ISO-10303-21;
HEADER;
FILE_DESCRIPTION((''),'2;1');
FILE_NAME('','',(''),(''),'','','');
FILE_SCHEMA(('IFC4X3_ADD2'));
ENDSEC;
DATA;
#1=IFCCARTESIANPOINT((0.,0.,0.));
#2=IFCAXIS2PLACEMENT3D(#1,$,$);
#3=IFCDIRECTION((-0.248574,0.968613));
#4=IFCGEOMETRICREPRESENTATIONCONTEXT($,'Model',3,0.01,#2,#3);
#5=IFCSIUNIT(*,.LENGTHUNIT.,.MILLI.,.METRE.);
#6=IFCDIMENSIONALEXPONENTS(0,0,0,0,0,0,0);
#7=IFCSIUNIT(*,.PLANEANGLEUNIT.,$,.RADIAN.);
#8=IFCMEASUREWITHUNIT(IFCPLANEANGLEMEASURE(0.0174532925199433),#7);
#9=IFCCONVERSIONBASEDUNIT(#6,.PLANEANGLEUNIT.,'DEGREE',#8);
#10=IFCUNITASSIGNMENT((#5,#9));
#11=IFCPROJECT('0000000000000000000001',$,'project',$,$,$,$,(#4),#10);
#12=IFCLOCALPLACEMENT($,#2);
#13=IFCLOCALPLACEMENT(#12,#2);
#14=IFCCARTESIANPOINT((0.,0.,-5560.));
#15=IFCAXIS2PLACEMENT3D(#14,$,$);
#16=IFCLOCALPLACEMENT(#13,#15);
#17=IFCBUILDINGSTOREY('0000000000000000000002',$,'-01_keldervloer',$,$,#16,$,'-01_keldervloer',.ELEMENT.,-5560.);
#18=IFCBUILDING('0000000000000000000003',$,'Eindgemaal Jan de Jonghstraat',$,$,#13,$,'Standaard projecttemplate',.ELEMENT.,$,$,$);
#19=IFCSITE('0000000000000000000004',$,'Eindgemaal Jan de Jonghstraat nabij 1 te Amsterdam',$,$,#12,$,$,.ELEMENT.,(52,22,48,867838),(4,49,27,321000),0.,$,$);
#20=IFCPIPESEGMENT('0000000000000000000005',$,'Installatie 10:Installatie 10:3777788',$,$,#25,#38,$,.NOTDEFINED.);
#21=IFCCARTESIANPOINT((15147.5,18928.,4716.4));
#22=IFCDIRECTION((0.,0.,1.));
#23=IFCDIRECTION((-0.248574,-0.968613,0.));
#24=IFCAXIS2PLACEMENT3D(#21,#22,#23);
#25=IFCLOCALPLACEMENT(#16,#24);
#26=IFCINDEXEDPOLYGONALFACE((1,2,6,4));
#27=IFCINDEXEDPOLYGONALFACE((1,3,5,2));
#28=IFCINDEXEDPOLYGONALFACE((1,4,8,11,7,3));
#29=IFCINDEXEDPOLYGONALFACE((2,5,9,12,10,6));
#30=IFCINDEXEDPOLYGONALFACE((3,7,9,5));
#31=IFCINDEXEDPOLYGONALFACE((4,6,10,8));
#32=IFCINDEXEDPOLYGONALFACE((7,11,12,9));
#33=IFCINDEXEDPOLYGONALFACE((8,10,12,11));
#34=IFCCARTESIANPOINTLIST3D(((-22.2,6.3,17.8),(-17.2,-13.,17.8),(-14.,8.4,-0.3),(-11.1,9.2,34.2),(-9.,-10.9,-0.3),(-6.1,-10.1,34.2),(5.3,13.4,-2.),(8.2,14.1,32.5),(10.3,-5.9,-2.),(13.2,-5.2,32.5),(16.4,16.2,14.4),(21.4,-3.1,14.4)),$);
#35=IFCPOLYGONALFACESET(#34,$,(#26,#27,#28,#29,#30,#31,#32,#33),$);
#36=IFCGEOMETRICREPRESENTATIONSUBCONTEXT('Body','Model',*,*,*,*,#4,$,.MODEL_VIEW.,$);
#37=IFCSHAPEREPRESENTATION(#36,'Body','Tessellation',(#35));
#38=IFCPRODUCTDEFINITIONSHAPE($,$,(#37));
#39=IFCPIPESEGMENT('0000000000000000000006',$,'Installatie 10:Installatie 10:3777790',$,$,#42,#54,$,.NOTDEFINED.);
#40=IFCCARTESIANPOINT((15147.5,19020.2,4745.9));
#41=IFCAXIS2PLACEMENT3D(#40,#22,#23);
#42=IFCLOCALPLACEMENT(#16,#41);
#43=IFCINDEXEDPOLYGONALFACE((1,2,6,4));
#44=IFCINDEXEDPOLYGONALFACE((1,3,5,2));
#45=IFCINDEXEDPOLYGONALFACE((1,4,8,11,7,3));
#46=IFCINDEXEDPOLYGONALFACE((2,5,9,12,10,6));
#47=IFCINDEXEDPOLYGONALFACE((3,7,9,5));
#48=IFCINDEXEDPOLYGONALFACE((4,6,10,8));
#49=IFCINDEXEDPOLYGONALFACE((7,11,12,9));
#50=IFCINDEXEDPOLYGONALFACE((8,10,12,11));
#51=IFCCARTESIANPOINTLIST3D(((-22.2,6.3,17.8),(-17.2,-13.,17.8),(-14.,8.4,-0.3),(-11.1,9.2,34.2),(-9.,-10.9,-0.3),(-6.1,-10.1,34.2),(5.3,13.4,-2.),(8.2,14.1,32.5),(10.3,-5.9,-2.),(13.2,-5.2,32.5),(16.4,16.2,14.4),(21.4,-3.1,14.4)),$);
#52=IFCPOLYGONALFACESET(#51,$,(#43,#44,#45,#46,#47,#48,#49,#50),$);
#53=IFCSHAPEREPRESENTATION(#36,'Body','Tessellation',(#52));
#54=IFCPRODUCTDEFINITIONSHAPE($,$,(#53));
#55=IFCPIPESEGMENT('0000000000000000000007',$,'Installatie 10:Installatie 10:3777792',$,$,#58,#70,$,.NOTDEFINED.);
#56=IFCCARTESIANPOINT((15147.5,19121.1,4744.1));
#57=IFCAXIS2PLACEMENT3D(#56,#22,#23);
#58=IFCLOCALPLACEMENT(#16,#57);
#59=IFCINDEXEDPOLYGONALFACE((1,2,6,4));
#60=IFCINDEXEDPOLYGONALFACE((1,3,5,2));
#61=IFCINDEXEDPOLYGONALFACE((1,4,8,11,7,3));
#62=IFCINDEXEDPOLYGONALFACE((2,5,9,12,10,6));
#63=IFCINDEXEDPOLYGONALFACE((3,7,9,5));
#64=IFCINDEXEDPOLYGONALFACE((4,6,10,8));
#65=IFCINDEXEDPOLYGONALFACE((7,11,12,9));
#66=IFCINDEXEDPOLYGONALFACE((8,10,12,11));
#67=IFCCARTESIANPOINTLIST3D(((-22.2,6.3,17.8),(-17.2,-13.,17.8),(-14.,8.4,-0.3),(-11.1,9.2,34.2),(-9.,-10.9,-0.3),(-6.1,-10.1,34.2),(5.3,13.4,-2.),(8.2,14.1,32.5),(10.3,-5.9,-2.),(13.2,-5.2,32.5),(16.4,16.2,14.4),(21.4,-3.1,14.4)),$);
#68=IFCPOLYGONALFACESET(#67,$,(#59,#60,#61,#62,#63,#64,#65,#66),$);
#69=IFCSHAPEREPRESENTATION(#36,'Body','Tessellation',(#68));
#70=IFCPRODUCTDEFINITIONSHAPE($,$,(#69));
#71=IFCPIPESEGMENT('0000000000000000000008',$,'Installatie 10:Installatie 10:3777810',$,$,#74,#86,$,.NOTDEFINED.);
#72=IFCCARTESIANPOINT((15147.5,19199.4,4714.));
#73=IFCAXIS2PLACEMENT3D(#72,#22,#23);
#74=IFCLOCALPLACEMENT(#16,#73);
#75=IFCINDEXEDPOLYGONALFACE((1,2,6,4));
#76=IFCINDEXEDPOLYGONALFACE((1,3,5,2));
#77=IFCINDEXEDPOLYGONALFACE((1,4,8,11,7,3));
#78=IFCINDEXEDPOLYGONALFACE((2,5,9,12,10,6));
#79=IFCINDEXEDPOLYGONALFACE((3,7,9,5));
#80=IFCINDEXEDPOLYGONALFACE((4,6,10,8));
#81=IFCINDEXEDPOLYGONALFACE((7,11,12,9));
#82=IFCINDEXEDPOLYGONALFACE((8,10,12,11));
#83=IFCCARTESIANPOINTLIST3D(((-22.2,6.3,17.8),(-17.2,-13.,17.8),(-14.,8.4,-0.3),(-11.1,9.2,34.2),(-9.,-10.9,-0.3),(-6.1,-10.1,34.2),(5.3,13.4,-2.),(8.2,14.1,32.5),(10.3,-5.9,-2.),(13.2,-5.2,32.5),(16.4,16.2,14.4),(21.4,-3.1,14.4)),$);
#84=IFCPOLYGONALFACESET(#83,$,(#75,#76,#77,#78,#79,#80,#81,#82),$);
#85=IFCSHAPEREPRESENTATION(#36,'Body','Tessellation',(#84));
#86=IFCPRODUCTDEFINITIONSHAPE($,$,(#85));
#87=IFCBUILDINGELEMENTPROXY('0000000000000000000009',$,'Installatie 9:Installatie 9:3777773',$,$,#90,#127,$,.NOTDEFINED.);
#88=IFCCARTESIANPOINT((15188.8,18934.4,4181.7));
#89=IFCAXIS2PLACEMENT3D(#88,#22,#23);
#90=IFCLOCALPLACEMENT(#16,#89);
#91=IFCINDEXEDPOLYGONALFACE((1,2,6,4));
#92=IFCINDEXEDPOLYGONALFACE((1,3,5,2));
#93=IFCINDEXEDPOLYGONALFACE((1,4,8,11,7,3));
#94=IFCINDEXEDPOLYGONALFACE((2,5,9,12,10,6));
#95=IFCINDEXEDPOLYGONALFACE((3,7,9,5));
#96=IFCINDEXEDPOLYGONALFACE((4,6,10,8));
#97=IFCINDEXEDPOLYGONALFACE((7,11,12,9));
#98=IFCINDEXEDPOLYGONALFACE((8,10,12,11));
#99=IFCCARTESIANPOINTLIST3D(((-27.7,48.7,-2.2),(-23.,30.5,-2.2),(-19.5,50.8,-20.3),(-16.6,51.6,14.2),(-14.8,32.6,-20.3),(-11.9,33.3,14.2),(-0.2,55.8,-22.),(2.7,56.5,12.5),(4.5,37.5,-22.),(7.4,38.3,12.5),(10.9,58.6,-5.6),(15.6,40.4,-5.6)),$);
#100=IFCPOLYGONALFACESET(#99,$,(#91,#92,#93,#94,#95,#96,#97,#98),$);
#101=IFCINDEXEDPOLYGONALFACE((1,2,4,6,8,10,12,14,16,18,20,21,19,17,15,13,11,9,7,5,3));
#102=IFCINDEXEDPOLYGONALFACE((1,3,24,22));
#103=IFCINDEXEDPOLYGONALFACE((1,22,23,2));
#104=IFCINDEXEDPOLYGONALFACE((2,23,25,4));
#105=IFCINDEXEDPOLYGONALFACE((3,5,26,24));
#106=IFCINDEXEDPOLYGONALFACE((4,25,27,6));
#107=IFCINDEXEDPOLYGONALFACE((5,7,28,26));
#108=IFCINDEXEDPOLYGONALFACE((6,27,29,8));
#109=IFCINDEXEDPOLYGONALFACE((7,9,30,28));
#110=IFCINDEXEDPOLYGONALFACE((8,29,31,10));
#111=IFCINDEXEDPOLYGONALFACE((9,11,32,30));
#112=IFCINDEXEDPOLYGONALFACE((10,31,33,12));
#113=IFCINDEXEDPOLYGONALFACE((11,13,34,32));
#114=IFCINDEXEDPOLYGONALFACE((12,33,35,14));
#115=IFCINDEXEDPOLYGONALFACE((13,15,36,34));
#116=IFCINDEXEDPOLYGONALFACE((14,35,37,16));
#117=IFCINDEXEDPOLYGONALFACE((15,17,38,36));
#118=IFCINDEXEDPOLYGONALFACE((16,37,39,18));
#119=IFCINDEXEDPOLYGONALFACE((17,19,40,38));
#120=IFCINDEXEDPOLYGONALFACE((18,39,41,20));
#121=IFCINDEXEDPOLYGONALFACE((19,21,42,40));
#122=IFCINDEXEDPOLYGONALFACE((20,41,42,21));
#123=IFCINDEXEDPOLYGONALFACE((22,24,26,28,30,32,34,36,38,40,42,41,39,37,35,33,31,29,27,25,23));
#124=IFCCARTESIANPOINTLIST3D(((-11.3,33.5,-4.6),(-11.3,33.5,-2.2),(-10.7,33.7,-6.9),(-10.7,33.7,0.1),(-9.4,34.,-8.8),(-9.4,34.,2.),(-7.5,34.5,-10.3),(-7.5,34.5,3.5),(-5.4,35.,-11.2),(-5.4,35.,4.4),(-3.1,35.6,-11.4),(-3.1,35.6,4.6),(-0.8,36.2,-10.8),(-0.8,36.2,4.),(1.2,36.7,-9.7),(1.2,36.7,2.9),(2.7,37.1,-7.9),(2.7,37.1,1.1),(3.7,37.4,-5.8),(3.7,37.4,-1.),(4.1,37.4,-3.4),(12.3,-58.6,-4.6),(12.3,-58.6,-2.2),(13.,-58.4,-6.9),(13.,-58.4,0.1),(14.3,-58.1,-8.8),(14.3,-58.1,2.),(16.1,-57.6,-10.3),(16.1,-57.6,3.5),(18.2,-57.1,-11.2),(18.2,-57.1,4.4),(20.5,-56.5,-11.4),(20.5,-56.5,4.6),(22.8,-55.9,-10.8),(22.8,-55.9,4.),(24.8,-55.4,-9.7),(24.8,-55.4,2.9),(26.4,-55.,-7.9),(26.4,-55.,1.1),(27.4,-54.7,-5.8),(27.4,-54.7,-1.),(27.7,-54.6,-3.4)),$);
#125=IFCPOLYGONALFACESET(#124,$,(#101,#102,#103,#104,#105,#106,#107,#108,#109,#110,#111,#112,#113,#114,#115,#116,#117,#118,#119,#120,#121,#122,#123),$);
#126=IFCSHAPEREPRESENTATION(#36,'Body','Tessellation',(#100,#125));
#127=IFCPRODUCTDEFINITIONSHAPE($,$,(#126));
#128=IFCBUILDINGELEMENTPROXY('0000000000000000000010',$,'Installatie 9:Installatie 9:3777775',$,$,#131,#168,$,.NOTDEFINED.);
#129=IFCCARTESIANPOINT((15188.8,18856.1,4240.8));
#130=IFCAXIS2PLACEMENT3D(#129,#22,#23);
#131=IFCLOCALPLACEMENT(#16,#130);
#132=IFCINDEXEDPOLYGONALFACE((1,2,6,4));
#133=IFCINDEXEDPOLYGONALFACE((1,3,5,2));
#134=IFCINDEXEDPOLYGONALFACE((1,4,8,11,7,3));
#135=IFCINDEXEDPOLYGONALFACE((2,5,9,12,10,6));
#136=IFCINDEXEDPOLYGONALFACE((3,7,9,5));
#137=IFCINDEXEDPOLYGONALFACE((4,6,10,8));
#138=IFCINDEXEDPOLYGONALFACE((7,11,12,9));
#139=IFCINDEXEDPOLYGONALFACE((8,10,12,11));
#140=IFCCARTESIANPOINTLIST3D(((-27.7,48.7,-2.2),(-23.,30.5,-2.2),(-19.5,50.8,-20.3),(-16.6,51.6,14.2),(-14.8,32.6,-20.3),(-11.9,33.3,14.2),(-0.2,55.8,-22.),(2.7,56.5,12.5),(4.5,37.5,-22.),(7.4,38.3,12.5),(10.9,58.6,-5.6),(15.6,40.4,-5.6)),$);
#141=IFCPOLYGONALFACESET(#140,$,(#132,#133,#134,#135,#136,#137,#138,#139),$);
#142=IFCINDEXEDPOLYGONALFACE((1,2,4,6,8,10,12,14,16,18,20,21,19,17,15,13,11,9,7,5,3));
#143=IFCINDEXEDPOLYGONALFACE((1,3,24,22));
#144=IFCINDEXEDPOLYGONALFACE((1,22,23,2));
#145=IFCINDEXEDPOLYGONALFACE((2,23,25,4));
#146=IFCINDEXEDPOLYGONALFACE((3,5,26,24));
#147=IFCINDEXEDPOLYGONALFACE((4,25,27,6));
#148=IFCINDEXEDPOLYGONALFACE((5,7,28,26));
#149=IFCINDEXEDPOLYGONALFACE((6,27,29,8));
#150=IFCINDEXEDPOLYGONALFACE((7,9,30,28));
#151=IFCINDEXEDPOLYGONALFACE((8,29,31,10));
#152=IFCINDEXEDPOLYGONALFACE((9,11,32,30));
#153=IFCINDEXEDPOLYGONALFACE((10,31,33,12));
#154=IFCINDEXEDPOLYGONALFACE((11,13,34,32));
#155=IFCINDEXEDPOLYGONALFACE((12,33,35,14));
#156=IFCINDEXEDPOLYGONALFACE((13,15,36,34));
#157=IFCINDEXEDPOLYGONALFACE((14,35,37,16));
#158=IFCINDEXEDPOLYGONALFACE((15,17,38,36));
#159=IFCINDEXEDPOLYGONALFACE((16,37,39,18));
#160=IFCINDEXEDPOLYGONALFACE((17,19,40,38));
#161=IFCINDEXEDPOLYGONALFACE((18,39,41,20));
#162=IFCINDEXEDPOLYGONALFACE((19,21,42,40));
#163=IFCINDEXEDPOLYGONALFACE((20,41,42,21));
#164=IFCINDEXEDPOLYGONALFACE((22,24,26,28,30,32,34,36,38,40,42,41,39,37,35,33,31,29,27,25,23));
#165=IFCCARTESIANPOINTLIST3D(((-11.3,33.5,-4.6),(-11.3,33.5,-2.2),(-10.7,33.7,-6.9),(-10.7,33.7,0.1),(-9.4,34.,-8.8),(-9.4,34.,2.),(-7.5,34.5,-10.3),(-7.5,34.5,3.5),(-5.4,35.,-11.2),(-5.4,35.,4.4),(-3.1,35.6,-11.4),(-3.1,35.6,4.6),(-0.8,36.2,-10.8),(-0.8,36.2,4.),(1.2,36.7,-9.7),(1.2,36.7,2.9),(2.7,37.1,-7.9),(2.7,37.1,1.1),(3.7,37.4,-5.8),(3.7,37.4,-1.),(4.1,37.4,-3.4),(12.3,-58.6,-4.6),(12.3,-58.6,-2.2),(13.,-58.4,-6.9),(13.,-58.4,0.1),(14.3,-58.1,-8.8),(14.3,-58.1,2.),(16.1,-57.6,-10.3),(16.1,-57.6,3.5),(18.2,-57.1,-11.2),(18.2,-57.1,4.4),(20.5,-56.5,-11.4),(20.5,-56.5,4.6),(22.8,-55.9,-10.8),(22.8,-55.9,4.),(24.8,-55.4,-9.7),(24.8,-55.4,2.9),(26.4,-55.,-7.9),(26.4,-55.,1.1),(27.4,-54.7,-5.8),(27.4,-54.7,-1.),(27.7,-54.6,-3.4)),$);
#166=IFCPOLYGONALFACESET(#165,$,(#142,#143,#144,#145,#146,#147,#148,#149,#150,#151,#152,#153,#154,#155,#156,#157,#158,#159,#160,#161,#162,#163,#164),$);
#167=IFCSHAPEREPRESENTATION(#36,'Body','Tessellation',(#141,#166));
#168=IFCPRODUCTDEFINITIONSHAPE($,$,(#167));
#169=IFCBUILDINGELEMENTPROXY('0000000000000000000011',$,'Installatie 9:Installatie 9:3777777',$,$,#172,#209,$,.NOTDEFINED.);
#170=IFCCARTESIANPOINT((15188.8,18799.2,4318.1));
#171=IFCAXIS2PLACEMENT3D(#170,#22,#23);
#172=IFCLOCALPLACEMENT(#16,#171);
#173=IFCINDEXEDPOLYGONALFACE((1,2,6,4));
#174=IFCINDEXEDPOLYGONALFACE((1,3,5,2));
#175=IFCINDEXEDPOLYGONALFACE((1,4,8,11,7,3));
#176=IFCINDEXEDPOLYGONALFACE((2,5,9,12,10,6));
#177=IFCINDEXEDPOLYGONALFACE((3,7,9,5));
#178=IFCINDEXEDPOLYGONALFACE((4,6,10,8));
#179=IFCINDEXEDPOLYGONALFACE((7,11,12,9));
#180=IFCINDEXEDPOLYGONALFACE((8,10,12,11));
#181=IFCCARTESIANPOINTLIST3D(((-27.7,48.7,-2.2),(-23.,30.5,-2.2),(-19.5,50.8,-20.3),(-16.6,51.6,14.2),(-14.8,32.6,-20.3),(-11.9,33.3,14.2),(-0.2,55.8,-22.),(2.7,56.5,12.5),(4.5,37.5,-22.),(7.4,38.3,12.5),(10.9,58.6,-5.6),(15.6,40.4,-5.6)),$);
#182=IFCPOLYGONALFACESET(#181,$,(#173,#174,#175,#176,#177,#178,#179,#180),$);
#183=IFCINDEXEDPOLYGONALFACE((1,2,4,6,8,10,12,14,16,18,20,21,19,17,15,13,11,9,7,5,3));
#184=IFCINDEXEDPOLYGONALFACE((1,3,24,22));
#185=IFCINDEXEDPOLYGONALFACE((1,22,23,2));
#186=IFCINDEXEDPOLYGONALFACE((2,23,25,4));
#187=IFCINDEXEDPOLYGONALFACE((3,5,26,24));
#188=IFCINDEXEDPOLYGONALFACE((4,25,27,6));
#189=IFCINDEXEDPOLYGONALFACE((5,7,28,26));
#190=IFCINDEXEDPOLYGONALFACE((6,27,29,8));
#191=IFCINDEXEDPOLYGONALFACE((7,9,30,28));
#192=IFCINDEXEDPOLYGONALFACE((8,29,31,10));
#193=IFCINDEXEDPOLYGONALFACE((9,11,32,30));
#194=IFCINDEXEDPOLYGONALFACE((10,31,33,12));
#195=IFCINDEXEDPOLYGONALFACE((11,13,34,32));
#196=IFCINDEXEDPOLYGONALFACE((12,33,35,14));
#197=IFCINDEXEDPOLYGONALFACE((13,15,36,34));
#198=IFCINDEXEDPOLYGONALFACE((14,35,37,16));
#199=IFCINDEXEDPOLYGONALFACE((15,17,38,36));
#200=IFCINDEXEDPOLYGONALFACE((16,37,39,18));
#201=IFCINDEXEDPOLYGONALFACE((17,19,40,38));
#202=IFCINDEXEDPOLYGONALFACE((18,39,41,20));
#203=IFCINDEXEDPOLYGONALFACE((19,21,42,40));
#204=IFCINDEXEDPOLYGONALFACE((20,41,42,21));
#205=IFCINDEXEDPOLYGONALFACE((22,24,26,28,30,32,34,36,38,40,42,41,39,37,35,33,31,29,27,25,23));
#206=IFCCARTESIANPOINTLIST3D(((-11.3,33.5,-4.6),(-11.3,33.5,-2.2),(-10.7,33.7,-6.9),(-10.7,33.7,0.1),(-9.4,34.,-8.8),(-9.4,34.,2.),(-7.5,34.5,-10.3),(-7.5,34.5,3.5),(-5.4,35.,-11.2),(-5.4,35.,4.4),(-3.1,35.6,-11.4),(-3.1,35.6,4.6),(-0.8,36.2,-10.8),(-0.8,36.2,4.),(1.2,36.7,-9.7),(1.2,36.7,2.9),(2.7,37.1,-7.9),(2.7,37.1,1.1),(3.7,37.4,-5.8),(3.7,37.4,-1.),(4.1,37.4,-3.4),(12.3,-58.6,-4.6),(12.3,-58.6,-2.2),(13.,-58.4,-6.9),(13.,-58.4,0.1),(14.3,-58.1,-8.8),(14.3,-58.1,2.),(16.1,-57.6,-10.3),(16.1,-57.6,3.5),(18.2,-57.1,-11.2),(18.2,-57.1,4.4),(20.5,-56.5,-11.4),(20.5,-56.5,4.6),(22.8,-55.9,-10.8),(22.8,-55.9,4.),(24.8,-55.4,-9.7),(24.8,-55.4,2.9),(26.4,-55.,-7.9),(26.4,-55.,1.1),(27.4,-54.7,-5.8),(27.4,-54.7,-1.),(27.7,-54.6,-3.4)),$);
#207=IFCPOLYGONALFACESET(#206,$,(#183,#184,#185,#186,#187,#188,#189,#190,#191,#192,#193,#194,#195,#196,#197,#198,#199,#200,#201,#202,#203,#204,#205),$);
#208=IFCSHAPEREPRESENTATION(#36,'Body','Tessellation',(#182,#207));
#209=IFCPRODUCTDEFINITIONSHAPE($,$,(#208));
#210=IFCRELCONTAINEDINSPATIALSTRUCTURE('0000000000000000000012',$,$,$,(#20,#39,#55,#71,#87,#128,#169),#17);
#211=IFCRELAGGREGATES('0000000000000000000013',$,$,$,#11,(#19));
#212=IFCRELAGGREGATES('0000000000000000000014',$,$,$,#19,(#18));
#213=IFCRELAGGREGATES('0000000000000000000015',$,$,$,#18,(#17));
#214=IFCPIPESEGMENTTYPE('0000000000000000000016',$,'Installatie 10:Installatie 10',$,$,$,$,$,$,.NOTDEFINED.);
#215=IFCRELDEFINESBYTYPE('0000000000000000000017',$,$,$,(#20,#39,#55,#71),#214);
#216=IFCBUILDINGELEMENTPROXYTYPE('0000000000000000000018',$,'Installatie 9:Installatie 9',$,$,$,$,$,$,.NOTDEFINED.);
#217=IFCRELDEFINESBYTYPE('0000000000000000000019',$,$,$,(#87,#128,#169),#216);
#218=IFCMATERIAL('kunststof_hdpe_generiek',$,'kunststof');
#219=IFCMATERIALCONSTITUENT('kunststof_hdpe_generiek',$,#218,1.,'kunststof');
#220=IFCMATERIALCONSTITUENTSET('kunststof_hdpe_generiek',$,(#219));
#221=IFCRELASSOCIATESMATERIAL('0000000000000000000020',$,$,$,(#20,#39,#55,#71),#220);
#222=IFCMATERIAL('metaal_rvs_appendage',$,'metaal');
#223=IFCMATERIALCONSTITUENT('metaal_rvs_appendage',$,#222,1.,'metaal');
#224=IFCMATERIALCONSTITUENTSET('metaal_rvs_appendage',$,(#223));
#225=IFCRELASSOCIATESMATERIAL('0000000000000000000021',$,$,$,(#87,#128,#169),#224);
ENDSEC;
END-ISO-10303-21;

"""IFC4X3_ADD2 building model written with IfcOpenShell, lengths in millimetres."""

from ifc_helpers import new_model, entity, si_unit, converted_unit, direction, frame, frame_2d, origin, place, context, subcontext, project, spatial, polyline, circle, outline, extrude, source, transform, mapped, material, constituent, constituent_set, type_object, type_shapes, element, save


model = new_model("IFC4X3_ADD2")

# Units and contexts
model_context = context("Model", 3, precision=0.01, world=origin(), true_north=direction((-0.248574, 0.968613)))
body_context = subcontext(model_context, "Body", "Model", "MODEL_VIEW")
ifc_project = project(units=[si_unit("LENGTHUNIT", "METRE", prefix="MILLI"), converted_unit("PLANEANGLEUNIT", "DEGREE", entity("IfcPlaneAngleMeasure", 0.0174532925199433), si_unit("PLANEANGLEUNIT", "RADIAN"), dimensions=[0, 0, 0, 0, 0, 0, 0])], contexts=[model_context])

# Site, building, storey
site_placement = place(None, origin())
site = spatial("IfcSite", under=ifc_project, at=site_placement, Name="Eindgemaal Jan de Jonghstraat nabij 1 te Amsterdam", CompositionType="ELEMENT", RefLatitude=(52, 22, 48, 867838), RefLongitude=(4, 49, 27, 321000), RefElevation=0.0)
building_placement = place(site_placement, origin())
building = spatial("IfcBuilding", under=site, at=building_placement, Name="Eindgemaal Jan de Jonghstraat", LongName="Standaard projecttemplate", CompositionType="ELEMENT")
storey_placement = place(building_placement, frame((0.0, 0.0, -5560.0)))
storey = spatial("IfcBuildingStorey", under=building, at=storey_placement, Name="-01_keldervloer", LongName="-01_keldervloer", CompositionType="ELEMENT", Elevation=-5560.0)

# Pipe segments
ifc_material_1 = material(Name="kunststof_hdpe_generiek", Category="kunststof")
ifc_constituent_1 = constituent(ifc_material_1, Name="kunststof_hdpe_generiek", Category="kunststof", fraction=1.0)
ifc_constituent_set_1 = constituent_set(constituents=[ifc_constituent_1], Name="kunststof_hdpe_generiek")
pipe_segment_type = type_object("IfcPipeSegmentType", Name="Installatie 10:Installatie 10", PredefinedType="NOTDEFINED")
shared_shape_1 = source(origin(), body_context, "Body", "SweptSolid", [
    extrude(outline(polyline([(-10.0, -17.3), (10.0, -17.3), (20.0, 0.0), (10.0, 17.3), (-10.0, 17.3), (-20.0, 0.0), (-10.0, -17.3)])), frame((2.1, -8.0, 16.1), z_axis=(-0.248574, 0.968613, 0.0), x_axis=(0.409353, 0.105052, -0.906308)), (0.0, 0.0, 1.0), 19.9),
])
type_shapes(pipe_segment_type, [shared_shape_1])
for number, where, z_axis, x_axis, name in (
    (1, (15147.5, 18928.0, 4716.4), (0.0, 0.0, 1.0), (-0.248574, -0.968613, 0.0), "Installatie 10:Installatie 10:3777788"),
    (2, (15147.5, 19020.2, 4745.9), (0.0, 0.0, 1.0), (-0.248574, -0.968613, 0.0), "Installatie 10:Installatie 10:3777790"),
    (3, (15147.5, 19121.1, 4744.1), (0.0, 0.0, 1.0), (-0.248574, -0.968613, 0.0), "Installatie 10:Installatie 10:3777792"),
    (4, (15147.5, 19199.4, 4714.0), (0.0, 0.0, 1.0), (-0.248574, -0.968613, 0.0), "Installatie 10:Installatie 10:3777810"),
):
    element("IfcPipeSegment", number, at=place(storey_placement, frame(where, z_axis=z_axis, x_axis=x_axis)), inside=storey, type_object=pipe_segment_type, material=ifc_constituent_set_1, Name=name, PredefinedType="NOTDEFINED", context=body_context, shape_type="MappedRepresentation", body=[
        mapped(shared_shape_1, transform((0.0, 0.0, 0.0), scale=1.0)),
    ])

# Building element proxies
ifc_material_2 = material(Name="metaal_rvs_appendage", Category="metaal")
ifc_constituent_2 = constituent(ifc_material_2, Name="metaal_rvs_appendage", Category="metaal", fraction=1.0)
ifc_constituent_set_2 = constituent_set(constituents=[ifc_constituent_2], Name="metaal_rvs_appendage")
building_element_proxy_type = type_object("IfcBuildingElementProxyType", Name="Installatie 9:Installatie 9", PredefinedType="NOTDEFINED")
shared_shape_2 = source(origin(), body_context, "Body", "SweptSolid", [
    extrude(outline(polyline([(-10.0, -17.3), (10.0, -17.3), (20.0, 0.0), (10.0, 17.3), (-10.0, 17.3), (-20.0, 0.0), (-10.0, -17.3)])), frame((-3.7, 35.4, -3.9), z_axis=(-0.248574, 0.968613, 0.0), x_axis=(-0.555573, -0.142576, -0.819152)), (0.0, 0.0, 1.0), 18.8),
    extrude(circle(Radius=8.0, at=frame_2d((0.0, 0.0), x_axis=(1.0, 0.0))), frame((20.0, -56.6, -3.4), z_axis=(-0.248574, 0.968613, 0.0), x_axis=(0.968613, 0.248574, 0.0)), (0.0, 0.0, 1.0), 95.1),
])
type_shapes(building_element_proxy_type, [shared_shape_2])
for number, where, z_axis, x_axis, name in (
    (5, (15188.8, 18934.4, 4181.7), (0.0, 0.0, 1.0), (-0.248574, -0.968613, 0.0), "Installatie 9:Installatie 9:3777773"),
    (6, (15188.8, 18856.1, 4240.8), (0.0, 0.0, 1.0), (-0.248574, -0.968613, 0.0), "Installatie 9:Installatie 9:3777775"),
    (7, (15188.8, 18799.2, 4318.1), (0.0, 0.0, 1.0), (-0.248574, -0.968613, 0.0), "Installatie 9:Installatie 9:3777777"),
):
    element("IfcBuildingElementProxy", number, at=place(storey_placement, frame(where, z_axis=z_axis, x_axis=x_axis)), inside=storey, type_object=building_element_proxy_type, material=ifc_constituent_set_2, Name=name, PredefinedType="NOTDEFINED", context=body_context, shape_type="MappedRepresentation", body=[
        mapped(shared_shape_2, transform((0.0, 0.0, 0.0), scale=1.0)),
    ])

save(model, "model.ifc")
